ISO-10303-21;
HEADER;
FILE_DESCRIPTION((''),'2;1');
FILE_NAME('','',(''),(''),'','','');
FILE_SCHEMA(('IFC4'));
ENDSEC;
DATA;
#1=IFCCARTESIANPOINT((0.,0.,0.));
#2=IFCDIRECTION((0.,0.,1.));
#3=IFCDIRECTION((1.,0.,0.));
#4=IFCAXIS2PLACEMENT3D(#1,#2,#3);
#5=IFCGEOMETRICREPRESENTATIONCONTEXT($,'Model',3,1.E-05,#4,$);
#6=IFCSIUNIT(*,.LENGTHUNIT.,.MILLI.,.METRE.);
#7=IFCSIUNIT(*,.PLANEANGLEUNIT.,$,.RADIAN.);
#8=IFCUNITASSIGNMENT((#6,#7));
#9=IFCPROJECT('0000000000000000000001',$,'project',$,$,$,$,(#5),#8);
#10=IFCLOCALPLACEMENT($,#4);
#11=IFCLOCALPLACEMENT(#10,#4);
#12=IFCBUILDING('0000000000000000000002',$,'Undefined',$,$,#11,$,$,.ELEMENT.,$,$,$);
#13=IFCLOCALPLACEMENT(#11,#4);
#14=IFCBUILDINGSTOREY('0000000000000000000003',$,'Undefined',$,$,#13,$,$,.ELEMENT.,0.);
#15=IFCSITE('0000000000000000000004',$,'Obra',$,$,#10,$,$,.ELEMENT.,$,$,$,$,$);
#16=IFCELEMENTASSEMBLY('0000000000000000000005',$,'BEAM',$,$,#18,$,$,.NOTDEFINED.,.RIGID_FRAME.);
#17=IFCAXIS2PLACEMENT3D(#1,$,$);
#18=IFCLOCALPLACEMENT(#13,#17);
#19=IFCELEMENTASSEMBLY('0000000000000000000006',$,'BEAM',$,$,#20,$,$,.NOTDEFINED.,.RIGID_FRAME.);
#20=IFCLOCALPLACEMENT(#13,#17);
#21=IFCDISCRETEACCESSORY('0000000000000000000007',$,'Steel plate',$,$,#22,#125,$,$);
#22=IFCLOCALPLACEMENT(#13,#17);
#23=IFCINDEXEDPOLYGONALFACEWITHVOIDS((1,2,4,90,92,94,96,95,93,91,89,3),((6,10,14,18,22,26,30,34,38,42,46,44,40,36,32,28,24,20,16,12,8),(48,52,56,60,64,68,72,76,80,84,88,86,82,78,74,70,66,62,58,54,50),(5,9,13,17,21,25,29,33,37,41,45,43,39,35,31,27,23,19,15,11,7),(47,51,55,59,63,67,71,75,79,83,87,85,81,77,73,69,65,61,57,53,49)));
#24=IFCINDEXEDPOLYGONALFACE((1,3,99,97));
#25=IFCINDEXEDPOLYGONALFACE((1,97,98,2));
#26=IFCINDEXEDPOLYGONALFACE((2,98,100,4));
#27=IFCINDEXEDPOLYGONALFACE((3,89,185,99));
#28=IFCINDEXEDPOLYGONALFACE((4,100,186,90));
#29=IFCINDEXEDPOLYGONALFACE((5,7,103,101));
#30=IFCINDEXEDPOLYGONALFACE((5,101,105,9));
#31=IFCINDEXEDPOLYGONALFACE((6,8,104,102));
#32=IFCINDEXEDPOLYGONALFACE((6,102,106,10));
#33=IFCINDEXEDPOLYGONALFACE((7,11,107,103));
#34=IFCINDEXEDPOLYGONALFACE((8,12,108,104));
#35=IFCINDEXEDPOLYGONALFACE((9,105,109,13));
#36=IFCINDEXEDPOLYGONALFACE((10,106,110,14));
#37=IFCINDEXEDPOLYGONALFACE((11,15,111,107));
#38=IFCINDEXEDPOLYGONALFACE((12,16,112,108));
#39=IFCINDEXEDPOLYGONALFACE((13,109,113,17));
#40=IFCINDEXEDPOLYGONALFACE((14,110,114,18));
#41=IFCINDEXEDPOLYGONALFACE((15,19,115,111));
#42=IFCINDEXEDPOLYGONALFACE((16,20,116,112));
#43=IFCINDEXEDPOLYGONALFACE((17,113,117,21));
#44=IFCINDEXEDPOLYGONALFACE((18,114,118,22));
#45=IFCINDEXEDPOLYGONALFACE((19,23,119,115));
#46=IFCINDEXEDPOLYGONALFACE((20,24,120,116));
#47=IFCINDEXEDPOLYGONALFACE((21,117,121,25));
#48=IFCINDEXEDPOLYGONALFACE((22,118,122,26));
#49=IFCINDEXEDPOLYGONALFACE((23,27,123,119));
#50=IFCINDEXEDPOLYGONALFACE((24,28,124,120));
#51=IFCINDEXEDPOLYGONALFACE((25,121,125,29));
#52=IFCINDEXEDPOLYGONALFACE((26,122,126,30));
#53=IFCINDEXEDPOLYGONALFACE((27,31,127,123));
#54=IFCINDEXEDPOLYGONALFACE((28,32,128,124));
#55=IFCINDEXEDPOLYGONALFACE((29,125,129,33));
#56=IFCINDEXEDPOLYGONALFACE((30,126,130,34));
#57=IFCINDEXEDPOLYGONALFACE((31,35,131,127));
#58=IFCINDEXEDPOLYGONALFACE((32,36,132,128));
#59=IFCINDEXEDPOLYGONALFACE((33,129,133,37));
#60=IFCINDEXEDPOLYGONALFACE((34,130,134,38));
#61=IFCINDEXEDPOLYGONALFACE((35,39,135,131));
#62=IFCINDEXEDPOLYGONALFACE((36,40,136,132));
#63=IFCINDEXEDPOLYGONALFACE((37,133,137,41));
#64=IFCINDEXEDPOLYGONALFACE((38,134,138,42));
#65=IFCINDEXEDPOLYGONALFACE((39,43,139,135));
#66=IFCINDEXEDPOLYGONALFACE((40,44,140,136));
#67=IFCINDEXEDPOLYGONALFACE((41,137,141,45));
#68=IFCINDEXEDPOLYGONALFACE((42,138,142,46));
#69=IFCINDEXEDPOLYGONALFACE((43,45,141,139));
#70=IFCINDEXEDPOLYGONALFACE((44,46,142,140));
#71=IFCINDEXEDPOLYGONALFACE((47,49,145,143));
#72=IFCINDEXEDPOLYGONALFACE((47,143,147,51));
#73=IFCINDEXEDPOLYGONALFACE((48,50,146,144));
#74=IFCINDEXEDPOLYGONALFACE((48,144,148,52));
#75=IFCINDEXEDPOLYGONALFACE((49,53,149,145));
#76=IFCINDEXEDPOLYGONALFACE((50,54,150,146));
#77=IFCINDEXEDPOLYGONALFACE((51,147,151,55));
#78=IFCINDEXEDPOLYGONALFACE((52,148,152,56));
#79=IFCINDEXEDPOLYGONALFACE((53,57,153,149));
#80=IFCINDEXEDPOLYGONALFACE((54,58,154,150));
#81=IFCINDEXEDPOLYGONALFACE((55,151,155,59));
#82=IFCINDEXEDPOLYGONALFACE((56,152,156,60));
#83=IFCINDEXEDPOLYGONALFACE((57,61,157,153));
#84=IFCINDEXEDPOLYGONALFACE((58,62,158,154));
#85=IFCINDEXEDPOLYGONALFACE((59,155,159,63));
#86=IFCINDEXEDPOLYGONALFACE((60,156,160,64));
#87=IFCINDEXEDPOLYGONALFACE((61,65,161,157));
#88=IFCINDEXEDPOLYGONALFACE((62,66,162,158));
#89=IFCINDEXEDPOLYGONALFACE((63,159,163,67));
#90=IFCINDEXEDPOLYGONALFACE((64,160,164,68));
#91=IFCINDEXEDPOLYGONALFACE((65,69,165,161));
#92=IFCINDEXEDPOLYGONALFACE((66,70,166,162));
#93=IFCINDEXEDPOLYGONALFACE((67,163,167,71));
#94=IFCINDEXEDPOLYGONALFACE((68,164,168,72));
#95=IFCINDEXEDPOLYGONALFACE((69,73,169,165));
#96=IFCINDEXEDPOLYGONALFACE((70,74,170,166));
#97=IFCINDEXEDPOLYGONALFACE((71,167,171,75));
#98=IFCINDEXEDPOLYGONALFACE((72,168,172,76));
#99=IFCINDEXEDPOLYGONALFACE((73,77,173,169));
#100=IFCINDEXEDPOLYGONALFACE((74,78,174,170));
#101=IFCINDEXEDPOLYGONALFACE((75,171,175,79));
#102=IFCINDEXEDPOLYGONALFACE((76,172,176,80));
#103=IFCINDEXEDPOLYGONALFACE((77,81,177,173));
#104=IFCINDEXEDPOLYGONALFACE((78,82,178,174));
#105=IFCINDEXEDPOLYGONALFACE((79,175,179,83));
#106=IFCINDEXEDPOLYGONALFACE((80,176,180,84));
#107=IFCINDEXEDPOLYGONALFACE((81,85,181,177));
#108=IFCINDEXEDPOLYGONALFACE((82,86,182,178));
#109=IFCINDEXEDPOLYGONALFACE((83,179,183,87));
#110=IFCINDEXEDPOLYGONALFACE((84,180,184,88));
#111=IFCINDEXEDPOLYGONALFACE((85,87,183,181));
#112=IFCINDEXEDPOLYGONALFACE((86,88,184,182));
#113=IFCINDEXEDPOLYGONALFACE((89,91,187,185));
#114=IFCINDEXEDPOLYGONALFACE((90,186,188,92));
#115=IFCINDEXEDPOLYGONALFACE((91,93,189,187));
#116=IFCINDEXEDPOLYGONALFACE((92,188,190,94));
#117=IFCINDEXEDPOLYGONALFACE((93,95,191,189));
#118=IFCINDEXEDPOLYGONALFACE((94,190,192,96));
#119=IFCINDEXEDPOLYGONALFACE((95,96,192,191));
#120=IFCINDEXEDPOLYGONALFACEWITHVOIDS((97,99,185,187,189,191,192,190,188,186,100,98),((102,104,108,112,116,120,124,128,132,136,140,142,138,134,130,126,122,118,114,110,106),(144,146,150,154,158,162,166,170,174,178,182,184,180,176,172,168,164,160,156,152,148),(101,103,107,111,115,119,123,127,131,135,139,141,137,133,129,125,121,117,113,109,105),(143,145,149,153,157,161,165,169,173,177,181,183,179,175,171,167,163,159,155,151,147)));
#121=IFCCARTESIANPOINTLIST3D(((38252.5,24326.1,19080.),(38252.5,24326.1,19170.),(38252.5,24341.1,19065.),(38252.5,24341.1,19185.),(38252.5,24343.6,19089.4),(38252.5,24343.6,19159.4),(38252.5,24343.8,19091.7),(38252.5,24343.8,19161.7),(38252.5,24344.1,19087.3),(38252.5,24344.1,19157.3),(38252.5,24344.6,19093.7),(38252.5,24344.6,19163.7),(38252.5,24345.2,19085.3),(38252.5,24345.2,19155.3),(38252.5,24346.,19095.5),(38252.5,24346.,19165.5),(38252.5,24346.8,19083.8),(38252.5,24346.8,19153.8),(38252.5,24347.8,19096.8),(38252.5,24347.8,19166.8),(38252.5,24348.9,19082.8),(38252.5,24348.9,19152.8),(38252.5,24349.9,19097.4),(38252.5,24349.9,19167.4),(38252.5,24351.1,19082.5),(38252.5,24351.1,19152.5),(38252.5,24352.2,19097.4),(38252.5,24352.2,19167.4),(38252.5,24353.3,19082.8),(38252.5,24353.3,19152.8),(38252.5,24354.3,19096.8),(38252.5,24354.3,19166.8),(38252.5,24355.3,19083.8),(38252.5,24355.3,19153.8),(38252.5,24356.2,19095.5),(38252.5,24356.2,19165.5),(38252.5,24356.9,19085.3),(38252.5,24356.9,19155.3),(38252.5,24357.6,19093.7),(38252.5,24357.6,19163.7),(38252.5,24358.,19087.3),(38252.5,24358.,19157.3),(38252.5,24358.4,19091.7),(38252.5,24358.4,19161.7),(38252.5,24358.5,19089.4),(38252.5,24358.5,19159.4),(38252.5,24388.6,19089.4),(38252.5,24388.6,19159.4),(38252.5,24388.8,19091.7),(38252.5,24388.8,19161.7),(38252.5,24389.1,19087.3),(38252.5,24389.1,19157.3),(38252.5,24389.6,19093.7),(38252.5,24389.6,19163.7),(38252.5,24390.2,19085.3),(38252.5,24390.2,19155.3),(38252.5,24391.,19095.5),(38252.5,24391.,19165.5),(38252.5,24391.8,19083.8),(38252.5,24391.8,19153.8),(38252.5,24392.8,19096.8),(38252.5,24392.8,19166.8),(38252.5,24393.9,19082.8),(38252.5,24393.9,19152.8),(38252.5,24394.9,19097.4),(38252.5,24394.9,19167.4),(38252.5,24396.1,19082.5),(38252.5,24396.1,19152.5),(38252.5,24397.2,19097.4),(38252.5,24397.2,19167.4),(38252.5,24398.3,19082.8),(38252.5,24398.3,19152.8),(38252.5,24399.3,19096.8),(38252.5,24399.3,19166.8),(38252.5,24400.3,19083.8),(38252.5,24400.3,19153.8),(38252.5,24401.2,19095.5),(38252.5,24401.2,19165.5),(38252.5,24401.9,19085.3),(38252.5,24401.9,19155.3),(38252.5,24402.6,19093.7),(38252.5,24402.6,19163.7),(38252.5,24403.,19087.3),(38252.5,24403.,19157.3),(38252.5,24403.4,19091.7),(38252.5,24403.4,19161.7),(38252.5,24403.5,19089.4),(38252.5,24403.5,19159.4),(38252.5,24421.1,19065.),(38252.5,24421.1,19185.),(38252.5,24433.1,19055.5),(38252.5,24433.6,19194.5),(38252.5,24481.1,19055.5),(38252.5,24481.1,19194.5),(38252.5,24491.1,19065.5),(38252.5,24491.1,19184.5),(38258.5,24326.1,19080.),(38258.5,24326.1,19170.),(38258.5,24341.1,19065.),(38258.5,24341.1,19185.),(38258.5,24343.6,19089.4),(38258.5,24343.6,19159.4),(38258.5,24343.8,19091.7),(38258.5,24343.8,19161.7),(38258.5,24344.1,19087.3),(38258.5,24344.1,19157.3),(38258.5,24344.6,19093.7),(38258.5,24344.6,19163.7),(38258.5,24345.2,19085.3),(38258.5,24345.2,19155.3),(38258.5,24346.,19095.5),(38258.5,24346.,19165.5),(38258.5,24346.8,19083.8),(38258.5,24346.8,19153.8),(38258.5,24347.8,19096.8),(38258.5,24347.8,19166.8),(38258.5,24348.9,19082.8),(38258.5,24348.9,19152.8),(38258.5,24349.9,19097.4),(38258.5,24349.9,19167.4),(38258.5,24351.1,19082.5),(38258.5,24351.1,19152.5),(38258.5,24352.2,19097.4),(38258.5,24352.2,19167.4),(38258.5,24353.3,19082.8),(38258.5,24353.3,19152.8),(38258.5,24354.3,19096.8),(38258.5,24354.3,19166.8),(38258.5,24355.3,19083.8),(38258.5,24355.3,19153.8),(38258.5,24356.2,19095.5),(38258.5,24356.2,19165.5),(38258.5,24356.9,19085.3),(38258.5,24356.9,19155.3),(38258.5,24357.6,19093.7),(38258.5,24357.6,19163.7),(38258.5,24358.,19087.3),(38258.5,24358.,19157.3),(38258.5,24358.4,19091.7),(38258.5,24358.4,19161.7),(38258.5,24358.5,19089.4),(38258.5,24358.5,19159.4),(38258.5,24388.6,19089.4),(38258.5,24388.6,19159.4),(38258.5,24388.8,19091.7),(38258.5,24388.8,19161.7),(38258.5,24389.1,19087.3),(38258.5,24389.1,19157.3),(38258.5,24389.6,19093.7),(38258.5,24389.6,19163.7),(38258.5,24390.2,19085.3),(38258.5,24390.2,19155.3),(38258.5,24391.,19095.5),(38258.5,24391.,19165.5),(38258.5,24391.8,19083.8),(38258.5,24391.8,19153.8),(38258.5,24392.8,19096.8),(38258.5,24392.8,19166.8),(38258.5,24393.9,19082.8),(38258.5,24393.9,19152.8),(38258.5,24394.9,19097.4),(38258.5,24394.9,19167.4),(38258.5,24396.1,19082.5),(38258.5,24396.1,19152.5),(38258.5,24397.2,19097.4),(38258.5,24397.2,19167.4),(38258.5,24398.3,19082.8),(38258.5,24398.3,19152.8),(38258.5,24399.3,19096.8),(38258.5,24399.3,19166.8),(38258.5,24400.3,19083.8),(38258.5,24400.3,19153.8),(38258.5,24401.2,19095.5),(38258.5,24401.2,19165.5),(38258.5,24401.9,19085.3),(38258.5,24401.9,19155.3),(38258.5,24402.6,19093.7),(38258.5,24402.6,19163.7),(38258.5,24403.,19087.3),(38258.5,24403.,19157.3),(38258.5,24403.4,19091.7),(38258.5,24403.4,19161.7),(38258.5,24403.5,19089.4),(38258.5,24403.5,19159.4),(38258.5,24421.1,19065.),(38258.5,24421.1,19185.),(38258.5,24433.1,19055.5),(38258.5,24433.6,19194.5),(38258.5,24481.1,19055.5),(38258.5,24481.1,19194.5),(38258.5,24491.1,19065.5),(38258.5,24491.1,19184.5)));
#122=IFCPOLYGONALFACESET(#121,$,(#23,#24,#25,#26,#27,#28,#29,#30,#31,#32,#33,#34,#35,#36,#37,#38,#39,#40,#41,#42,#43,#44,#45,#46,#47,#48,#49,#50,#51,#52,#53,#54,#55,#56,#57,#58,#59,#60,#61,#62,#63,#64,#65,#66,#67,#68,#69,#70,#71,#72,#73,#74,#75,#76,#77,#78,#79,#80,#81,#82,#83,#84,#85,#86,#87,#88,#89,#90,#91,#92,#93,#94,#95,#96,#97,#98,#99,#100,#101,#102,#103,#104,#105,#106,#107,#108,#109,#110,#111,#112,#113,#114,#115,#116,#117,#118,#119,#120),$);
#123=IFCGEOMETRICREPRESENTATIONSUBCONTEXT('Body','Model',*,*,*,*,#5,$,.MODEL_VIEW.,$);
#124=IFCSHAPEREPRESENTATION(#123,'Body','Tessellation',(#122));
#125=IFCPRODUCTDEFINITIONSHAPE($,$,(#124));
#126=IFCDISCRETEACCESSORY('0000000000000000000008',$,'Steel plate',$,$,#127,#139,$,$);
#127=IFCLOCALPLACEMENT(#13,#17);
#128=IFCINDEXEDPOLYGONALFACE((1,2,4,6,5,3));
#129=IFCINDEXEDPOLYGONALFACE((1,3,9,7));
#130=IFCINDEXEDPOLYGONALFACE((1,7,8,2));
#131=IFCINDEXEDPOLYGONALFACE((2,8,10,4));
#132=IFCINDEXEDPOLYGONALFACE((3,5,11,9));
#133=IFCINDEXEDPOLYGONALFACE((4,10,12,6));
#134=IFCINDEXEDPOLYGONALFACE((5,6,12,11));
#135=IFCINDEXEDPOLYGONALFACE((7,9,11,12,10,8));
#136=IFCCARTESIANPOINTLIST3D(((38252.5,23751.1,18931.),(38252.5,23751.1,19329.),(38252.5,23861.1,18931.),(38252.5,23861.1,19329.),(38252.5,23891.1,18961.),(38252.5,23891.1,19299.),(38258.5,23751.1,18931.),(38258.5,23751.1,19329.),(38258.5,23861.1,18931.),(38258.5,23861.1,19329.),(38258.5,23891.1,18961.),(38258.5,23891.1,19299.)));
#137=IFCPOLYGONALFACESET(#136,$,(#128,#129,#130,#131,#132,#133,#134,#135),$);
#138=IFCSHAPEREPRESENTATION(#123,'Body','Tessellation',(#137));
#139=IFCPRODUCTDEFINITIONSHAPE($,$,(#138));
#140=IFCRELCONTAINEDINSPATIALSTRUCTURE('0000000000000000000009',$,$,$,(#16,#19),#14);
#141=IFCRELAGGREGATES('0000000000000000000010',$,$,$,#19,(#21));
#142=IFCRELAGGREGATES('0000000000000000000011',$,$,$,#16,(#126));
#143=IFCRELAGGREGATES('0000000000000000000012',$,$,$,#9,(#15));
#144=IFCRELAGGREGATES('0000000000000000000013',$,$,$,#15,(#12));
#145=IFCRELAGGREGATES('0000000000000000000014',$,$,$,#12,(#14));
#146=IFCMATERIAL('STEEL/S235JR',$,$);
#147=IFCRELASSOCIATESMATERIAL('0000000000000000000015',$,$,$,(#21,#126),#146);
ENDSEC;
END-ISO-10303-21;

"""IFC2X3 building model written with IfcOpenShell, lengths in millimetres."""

from ifc_helpers import new_model, si_unit, frame, origin_with_axes, origin_2d_with_axis, place, context, subcontext, project, spatial, polyline, circle, outline, extrude, source, transform, mapped, material, element, aggregate, save


model = new_model("IFC2X3")

# Units and contexts
model_context = context("Model", 3, precision=1e-05, world=origin_with_axes())
body_context = subcontext(model_context, "Body", "Model", "MODEL_VIEW")
ifc_project = project(units=[si_unit("LENGTHUNIT", "METRE", prefix="MILLI"), si_unit("PLANEANGLEUNIT", "RADIAN")], contexts=[model_context])

# Site, building, storey
site_placement = place(None, origin_with_axes())
site = spatial("IfcSite", under=ifc_project, at=site_placement, Name="Obra", CompositionType="ELEMENT")
building_placement = place(site_placement, origin_with_axes())
building = spatial("IfcBuilding", under=site, at=building_placement, Name="Undefined", CompositionType="ELEMENT")
storey_placement = place(building_placement, origin_with_axes())
storey = spatial("IfcBuildingStorey", under=building, at=storey_placement, Name="Undefined", CompositionType="ELEMENT", Elevation=0.0)

# Shared definitions
ifc_material_1 = material(Name="STEEL/S235JR")

# Element assembly
assembly_1_placement = place(storey_placement, origin_with_axes())
assembly_1 = element("IfcElementAssembly", 1, at=assembly_1_placement, inside=storey, Name="BEAM", AssemblyPlace="NOTDEFINED", PredefinedType="RIGID_FRAME")

# Element assembly, discrete accessory, opening
assembly_2_placement = place(storey_placement, origin_with_axes())
assembly_2 = element("IfcElementAssembly", 2, at=assembly_2_placement, inside=storey, Name="BEAM", AssemblyPlace="NOTDEFINED", PredefinedType="RIGID_FRAME")
shared_shape_1 = source(origin_with_axes(), body_context, "Body", "SweptSolid", [
    extrude(circle(Radius=7.5, at=origin_2d_with_axis()), frame((0.0, 2.4, 0.0), z_axis=(0.0, 1.0, 0.0), x_axis=(1.0, 0.0, 0.0)), (0.0, 0.0, 1.0), 6.2),
])
discrete_accessory_1_placement = place(assembly_2_placement, frame((38255.5, 24491.1, 19065.5), z_axis=(-1.0, 0.0, 0.0), x_axis=(0.000001, -0.707107, -0.707107)))
discrete_accessory_1 = element("IfcDiscreteAccessory", 3, at=discrete_accessory_1_placement, material=ifc_material_1, Name="Steel plate", context=body_context, shape_type="SweptSolid", body=[
    extrude(outline(polyline([(0.0, 0.0), (14.1, 0.0), (48.1, 33.9), (49.9, 49.1), (106.4, 105.7), (106.4, 126.9), (42.8, 190.6), (21.6, 190.6), (-35.0, 134.0), (-50.6, 131.9), (-84.1, 98.3), (-84.1, 84.1), (0.0, 0.0)])), frame((0.0, 0.0, -3.0), z_axis=(0.0, 0.0, 1.0), x_axis=(1.0, 0.0, 0.0)), (0.0, 0.0, 1.0), 6.0),
])
opening_1_placement = place(assembly_2_placement, frame((38250.0, 24373.6, 19160.0), z_axis=(0.0, -1.0, 0.0), x_axis=(0.0, 0.0, -1.0)))
element("IfcOpeningElement", 4, at=opening_1_placement, cuts=discrete_accessory_1, ObjectType="Opening", context=body_context, shape_type="MappedRepresentation", body=[
    mapped(shared_shape_1, transform((0.0, 0.0, -22.5))),
    mapped(shared_shape_1, transform((70.0, 0.0, -22.5))),
    mapped(shared_shape_1, transform((0.0, 0.0, 22.5))),
    mapped(shared_shape_1, transform((70.0, 0.0, 22.5))),
])

# Discrete accessory
discrete_accessory_2_placement = place(assembly_1_placement, frame((38255.5, 23891.1, 18931.0), z_axis=(-1.0, 0.0, 0.0), x_axis=(0.0, -1.0, 0.0)))
discrete_accessory_2 = element("IfcDiscreteAccessory", 5, at=discrete_accessory_2_placement, material=ifc_material_1, Name="Steel plate", context=body_context, shape_type="SweptSolid", body=[
    extrude(outline(polyline([(0.0, 30.0), (30.0, 0.0), (140.0, 0.0), (140.0, 398.0), (30.0, 398.0), (0.0, 368.0), (0.0, 30.0)])), frame((0.0, 0.0, -3.0), z_axis=(0.0, 0.0, 1.0), x_axis=(1.0, 0.0, 0.0)), (0.0, 0.0, 1.0), 6.0),
])

aggregate(assembly_2, [discrete_accessory_1])

aggregate(assembly_1, [discrete_accessory_2])

save(model, "model.ifc")
